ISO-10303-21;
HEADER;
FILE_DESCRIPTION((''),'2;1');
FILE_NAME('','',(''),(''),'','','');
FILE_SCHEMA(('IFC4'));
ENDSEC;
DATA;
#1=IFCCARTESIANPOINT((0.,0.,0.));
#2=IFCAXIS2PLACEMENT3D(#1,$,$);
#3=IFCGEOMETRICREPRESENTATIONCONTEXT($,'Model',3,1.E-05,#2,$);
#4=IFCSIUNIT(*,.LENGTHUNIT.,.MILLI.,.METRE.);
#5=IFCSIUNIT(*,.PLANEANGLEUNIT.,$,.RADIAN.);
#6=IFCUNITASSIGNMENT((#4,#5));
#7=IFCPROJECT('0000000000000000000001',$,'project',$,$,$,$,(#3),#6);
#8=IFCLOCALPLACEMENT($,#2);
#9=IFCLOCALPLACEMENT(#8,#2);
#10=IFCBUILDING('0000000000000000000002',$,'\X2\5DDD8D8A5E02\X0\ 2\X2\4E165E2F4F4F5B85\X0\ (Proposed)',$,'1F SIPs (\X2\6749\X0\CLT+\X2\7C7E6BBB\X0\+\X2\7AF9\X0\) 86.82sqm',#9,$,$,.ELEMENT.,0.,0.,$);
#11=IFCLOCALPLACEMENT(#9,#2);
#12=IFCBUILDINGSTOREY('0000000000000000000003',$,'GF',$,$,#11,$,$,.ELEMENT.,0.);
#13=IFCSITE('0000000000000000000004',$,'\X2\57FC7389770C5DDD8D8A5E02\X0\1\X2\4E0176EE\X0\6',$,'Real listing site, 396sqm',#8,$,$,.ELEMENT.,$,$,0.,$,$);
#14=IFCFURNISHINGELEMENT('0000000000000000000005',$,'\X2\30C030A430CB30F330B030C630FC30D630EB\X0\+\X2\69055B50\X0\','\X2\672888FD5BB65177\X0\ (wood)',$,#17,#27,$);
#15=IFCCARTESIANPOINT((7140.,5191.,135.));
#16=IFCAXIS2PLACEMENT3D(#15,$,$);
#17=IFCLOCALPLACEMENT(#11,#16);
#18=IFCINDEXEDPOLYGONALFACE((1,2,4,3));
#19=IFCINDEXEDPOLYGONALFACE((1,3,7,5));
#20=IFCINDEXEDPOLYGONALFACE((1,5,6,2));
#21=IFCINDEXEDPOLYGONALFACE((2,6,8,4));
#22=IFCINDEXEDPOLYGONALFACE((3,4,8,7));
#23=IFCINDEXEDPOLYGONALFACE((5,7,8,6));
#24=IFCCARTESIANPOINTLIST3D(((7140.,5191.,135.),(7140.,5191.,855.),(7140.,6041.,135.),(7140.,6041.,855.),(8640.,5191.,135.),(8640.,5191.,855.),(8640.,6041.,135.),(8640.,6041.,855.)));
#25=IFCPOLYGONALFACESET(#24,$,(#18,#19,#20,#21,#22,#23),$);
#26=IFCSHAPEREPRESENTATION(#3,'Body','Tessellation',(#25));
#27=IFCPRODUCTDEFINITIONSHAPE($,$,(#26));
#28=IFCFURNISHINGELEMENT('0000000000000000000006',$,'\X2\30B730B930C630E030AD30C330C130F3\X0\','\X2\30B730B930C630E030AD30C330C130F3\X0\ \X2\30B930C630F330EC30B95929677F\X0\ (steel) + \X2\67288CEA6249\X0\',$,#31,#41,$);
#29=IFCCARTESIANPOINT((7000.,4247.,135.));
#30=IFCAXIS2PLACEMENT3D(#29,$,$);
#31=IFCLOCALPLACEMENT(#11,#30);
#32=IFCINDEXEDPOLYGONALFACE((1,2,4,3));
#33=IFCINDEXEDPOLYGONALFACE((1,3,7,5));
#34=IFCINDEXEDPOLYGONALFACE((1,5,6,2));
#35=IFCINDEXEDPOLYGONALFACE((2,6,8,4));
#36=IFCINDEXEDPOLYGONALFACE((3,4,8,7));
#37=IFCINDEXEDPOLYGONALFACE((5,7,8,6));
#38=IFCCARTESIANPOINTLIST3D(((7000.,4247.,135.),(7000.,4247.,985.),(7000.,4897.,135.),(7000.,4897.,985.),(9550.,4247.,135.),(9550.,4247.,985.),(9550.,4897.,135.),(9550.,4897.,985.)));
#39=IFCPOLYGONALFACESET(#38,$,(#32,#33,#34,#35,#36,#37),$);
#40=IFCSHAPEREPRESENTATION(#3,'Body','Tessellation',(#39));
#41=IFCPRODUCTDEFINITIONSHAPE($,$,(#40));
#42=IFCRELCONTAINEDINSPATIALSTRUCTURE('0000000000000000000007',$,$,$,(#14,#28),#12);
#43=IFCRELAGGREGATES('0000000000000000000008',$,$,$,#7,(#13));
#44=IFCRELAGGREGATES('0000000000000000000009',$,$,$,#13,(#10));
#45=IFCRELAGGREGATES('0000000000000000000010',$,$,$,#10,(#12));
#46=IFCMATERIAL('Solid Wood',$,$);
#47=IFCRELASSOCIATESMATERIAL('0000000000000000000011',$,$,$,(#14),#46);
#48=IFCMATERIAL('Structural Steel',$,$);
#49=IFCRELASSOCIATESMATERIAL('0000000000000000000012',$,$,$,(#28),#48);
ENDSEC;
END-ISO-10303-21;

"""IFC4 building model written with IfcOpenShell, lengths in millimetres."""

from ifc_helpers import new_model, si_unit, frame, frame_2d, origin, place, context, project, spatial, rectangle, extrude, material, element, save


model = new_model("IFC4")

# Units and contexts
model_context = context("Model", 3, precision=1e-05, world=origin())
ifc_project = project(units=[si_unit("LENGTHUNIT", "METRE", prefix="MILLI"), si_unit("PLANEANGLEUNIT", "RADIAN")], contexts=[model_context])

# Site, building, storey
site_placement = place(None, origin())
site = spatial("IfcSite", under=ifc_project, at=site_placement, Name="埼玉県川越市1丁目6", ObjectType="Real listing site, 396sqm", CompositionType="ELEMENT", RefElevation=0.0)
building_placement = place(site_placement, origin())
building = spatial("IfcBuilding", under=site, at=building_placement, Name="川越市 2世帯住宅 (Proposed)", ObjectType="1F SIPs (杉CLT+籾殻+竹) 86.82sqm", CompositionType="ELEMENT", ElevationOfRefHeight=0.0, ElevationOfTerrain=0.0)
storey_placement = place(building_placement, origin())
storey = spatial("IfcBuildingStorey", under=building, at=storey_placement, Name="GF", CompositionType="ELEMENT", Elevation=0.0)

# Shared definitions
ifc_material_1 = material(Name="Solid Wood")

# Shared definitions
ifc_material_2 = material(Name="Structural Steel")

# Furnishing elements
furnishing_1_placement = place(storey_placement, frame((7140.0, 5191.0, 135.0)))
element("IfcFurnishingElement", 1, at=furnishing_1_placement, inside=storey, material=ifc_material_1, Name="ダイニングテーブル+椅子", Description="木製家具 (wood)", context=model_context, shape_type="SweptSolid", body=[
    extrude(rectangle(XDim=1500.0, YDim=850.0, at=frame_2d((750.0, 425.0))), frame((7140.0, 5191.0, 135.0)), (0.0, 0.0, 1.0), 720.0),
])
furnishing_2_placement = place(storey_placement, frame((7000.0, 4247.0, 135.0)))
element("IfcFurnishingElement", 2, at=furnishing_2_placement, inside=storey, material=ifc_material_2, Name="システムキッチン", Description="システムキッチン ステンレス天板 (steel) + 木質扉", context=model_context, shape_type="SweptSolid", body=[
    extrude(rectangle(XDim=2550.0, YDim=650.0, at=frame_2d((1275.0, 325.0))), frame((7000.0, 4247.0, 135.0)), (0.0, 0.0, 1.0), 850.0),
])

save(model, "model.ifc")
